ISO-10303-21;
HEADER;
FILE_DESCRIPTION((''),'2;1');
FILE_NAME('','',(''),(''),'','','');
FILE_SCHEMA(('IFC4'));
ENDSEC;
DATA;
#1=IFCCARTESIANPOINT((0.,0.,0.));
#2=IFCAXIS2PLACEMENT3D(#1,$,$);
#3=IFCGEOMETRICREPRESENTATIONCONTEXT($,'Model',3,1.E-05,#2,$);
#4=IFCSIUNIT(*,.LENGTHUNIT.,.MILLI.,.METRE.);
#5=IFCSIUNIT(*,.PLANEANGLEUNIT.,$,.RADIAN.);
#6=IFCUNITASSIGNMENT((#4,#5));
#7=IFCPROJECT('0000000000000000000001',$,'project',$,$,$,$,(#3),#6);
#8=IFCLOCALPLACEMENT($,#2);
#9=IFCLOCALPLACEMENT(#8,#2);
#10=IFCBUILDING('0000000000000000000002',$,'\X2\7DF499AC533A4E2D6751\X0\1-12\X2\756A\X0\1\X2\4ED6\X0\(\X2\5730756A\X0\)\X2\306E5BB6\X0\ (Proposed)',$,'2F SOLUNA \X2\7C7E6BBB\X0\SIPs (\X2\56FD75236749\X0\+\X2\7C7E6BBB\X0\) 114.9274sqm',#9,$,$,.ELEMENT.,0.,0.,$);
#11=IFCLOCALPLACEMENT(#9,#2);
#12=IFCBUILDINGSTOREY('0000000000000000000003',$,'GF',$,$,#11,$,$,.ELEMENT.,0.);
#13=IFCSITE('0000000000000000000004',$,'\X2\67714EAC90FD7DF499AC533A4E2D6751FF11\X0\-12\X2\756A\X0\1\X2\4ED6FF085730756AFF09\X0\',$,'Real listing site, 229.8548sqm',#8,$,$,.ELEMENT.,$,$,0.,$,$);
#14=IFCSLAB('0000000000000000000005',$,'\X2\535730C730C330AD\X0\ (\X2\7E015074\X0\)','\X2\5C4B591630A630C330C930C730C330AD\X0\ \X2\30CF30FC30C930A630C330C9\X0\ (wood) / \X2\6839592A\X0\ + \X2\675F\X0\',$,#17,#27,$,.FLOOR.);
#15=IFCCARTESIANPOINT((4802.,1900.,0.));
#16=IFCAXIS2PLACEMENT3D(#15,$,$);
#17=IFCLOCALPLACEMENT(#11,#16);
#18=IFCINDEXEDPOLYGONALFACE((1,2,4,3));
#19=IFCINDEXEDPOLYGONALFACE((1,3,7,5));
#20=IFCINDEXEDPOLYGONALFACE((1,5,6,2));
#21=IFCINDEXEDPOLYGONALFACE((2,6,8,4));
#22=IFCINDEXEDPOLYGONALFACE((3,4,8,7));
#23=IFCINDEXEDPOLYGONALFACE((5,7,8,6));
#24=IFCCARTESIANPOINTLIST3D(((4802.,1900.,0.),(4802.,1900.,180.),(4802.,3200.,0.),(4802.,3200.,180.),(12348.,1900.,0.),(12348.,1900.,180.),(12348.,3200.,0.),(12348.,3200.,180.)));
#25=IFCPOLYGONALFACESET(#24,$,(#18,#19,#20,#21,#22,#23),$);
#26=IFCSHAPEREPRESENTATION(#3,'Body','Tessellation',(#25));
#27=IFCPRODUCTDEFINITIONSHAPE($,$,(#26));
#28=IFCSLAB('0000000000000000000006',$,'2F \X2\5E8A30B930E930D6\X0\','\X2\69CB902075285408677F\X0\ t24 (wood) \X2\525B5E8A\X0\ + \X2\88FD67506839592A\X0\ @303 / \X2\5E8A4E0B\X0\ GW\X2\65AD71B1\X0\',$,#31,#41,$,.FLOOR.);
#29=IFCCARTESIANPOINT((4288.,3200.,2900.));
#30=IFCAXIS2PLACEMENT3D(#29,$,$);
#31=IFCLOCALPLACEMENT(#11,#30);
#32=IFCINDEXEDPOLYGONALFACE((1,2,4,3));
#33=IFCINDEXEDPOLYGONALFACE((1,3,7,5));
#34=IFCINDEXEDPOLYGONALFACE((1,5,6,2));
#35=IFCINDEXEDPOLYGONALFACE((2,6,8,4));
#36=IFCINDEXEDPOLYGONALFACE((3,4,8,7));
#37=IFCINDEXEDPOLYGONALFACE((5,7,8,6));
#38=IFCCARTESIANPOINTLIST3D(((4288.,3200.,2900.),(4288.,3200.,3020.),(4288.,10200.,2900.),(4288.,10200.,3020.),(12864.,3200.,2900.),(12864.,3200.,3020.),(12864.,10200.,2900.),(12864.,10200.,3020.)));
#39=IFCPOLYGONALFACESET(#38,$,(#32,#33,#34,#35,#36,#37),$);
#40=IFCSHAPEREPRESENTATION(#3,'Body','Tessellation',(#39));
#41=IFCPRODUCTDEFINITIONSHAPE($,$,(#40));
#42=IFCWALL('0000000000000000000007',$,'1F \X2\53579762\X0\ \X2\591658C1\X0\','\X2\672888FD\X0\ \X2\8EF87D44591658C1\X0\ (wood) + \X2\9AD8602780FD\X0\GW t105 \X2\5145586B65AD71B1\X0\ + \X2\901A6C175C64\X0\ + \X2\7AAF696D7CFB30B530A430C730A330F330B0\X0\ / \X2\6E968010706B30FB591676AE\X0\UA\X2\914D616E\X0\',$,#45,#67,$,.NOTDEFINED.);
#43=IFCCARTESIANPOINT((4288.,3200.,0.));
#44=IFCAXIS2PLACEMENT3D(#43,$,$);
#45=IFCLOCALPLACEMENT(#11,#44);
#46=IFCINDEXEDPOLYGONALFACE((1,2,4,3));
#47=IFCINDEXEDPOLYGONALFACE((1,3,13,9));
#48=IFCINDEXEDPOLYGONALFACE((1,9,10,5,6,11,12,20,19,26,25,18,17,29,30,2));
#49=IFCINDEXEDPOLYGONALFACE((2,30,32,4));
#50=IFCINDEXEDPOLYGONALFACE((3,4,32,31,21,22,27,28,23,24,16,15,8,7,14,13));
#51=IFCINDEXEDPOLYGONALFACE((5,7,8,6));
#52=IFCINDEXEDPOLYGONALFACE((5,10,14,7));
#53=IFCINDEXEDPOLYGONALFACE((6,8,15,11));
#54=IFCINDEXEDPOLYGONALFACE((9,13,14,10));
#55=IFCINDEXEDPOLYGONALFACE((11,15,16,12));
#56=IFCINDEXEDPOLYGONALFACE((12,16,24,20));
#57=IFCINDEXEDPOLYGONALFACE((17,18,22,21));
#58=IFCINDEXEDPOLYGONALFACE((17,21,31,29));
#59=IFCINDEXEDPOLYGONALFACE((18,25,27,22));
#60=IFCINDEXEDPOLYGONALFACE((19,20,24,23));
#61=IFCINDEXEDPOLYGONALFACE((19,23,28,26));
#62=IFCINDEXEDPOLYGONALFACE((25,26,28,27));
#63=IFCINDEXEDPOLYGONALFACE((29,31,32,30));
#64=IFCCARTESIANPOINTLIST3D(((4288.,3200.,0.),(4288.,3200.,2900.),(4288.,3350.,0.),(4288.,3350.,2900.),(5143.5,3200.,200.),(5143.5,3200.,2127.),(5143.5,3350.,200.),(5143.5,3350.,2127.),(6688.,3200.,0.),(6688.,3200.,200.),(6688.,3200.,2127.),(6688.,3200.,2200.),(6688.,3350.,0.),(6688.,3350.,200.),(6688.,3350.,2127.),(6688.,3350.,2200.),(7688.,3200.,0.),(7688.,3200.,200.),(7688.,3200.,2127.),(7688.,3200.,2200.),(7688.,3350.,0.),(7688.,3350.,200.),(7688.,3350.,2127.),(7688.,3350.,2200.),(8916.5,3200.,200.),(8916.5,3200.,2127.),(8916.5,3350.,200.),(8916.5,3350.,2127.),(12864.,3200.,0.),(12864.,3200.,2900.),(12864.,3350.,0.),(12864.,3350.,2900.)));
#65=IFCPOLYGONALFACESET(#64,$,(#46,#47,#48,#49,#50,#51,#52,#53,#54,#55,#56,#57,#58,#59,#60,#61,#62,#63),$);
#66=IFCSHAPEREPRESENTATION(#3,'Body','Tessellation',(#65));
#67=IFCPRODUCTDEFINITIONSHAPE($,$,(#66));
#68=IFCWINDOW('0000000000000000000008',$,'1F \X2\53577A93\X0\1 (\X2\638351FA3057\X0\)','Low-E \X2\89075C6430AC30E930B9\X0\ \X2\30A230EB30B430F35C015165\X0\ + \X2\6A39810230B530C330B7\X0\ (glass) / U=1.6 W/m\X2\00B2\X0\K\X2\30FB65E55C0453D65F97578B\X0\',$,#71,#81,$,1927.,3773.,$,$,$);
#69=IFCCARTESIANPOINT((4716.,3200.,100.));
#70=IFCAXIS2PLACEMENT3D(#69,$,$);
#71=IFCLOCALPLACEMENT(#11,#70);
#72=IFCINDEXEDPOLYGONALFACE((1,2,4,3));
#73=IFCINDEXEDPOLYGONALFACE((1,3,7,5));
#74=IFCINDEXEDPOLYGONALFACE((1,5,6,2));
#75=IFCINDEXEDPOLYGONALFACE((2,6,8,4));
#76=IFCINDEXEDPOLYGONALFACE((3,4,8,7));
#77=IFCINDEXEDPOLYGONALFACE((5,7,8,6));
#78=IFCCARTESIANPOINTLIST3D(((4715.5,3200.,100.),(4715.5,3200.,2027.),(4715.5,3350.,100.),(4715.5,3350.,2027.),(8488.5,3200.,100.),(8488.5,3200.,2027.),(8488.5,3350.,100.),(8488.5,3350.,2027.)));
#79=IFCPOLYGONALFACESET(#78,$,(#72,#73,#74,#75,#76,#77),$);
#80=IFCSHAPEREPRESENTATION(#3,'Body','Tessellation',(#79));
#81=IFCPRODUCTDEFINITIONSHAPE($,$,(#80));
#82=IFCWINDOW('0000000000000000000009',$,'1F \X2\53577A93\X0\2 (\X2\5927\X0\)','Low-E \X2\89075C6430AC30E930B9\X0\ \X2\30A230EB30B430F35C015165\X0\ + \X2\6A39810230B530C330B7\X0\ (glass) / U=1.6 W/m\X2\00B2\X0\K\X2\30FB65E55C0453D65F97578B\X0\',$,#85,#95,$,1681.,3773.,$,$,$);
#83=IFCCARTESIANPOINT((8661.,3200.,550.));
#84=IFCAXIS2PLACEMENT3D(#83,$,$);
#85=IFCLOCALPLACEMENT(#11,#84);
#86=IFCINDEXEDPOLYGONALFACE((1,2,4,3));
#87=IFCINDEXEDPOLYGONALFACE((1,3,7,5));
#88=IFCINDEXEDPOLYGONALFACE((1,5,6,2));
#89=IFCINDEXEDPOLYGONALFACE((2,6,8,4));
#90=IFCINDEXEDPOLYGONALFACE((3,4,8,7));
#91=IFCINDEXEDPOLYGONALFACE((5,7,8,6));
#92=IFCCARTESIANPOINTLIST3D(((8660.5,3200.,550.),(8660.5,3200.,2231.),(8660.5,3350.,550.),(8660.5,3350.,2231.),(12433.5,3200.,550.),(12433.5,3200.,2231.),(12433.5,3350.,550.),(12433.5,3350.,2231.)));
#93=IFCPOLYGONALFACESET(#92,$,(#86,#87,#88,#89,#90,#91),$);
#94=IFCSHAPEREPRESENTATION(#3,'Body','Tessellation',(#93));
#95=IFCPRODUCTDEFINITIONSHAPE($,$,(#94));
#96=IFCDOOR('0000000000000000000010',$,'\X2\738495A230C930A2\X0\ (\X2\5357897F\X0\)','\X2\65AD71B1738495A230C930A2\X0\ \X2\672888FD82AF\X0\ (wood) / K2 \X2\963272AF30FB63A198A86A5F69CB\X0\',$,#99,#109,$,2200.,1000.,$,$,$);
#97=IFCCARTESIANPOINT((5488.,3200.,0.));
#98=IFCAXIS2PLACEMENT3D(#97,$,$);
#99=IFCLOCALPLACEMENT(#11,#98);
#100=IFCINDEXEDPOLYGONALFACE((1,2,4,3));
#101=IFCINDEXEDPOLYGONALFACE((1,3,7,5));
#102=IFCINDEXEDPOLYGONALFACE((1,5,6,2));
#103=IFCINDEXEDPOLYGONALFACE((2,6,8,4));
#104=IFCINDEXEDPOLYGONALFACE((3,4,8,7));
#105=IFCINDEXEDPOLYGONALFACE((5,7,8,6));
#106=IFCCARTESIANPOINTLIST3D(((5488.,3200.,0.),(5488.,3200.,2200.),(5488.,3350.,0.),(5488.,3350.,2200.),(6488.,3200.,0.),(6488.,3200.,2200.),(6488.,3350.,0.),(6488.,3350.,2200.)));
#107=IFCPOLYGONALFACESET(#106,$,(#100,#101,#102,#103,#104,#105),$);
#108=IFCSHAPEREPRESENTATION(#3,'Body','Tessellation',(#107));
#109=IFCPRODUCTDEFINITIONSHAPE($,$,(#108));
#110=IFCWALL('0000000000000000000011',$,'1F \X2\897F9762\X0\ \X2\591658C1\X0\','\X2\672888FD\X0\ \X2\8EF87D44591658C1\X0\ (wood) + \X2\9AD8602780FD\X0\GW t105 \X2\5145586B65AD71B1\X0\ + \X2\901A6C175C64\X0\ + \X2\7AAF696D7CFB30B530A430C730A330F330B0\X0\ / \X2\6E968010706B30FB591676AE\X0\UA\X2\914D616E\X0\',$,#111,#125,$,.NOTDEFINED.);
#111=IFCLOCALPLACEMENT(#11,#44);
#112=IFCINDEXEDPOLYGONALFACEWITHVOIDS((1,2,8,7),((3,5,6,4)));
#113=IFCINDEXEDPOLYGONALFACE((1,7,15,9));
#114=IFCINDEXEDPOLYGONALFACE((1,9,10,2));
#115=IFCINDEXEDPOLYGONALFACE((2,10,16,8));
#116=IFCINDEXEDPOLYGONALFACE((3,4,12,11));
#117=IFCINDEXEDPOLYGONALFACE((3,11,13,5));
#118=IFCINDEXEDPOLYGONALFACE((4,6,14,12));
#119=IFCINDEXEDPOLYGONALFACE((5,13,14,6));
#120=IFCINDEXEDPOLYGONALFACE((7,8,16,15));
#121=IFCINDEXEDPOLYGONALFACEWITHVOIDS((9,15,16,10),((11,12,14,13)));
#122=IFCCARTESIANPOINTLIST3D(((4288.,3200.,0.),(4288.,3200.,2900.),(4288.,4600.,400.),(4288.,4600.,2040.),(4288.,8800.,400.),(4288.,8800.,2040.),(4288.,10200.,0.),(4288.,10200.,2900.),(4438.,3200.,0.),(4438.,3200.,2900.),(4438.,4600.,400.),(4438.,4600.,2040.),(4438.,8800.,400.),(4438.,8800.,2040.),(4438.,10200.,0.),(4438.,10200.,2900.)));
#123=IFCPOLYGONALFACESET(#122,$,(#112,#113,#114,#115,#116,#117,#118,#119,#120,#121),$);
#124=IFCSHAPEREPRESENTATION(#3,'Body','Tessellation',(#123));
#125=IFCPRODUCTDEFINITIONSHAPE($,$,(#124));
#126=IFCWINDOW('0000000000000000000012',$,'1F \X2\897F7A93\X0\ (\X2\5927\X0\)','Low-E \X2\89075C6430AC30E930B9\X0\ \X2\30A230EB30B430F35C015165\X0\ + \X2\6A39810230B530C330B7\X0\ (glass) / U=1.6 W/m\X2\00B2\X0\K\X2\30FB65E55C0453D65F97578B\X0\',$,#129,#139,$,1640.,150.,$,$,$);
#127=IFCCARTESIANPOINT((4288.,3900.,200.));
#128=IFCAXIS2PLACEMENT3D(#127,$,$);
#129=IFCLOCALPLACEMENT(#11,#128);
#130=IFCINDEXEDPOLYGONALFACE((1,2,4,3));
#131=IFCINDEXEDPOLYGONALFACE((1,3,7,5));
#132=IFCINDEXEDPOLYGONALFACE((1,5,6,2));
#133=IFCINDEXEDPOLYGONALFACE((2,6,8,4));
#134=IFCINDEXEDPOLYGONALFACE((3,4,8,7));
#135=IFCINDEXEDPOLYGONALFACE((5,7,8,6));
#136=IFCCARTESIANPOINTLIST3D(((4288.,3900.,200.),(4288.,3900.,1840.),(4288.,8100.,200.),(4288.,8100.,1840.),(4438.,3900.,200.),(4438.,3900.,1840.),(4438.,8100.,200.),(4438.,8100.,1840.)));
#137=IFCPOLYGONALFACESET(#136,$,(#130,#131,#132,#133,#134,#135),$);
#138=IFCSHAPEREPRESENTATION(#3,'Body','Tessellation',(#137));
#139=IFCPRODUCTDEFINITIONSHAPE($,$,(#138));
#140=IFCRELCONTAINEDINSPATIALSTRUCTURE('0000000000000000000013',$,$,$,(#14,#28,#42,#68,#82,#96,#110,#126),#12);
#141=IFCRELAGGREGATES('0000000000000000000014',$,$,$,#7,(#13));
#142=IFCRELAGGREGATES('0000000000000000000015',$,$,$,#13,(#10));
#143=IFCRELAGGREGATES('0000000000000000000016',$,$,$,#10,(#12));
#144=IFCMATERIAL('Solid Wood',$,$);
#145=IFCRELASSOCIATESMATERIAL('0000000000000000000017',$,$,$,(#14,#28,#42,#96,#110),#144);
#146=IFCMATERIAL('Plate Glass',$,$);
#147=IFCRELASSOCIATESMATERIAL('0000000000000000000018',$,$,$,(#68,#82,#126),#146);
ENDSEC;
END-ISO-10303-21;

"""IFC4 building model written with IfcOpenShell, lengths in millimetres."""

from ifc_helpers import new_model, si_unit, frame, frame_2d, origin, place, context, project, spatial, rectangle, extrude, material, element, fill, save


model = new_model("IFC4")

# Units and contexts
model_context = context("Model", 3, precision=1e-05, world=origin())
ifc_project = project(units=[si_unit("LENGTHUNIT", "METRE", prefix="MILLI"), si_unit("PLANEANGLEUNIT", "RADIAN")], contexts=[model_context])

# Site, building, storey
site_placement = place(None, origin())
site = spatial("IfcSite", under=ifc_project, at=site_placement, Name="東京都練馬区中村１-12番1他（地番）", ObjectType="Real listing site, 229.8548sqm", CompositionType="ELEMENT", RefElevation=0.0)
building_placement = place(site_placement, origin())
building = spatial("IfcBuilding", under=site, at=building_placement, Name="練馬区中村1-12番1他(地番)の家 (Proposed)", ObjectType="2F SOLUNA 籾殻SIPs (国産杉+籾殻) 114.9274sqm", CompositionType="ELEMENT", ElevationOfRefHeight=0.0, ElevationOfTerrain=0.0)
storey_placement = place(building_placement, origin())
storey = spatial("IfcBuildingStorey", under=building, at=storey_placement, Name="GF", CompositionType="ELEMENT", Elevation=0.0)

# Slabs
ifc_material_1 = material(Name="Solid Wood")
slab_1_placement = place(storey_placement, frame((4802.0, 1900.0, 0.0)))
element("IfcSlab", 1, at=slab_1_placement, inside=storey, material=ifc_material_1, Name="南デッキ (縁側)", Description="屋外ウッドデッキ ハードウッド (wood) / 根太 + 束", PredefinedType="FLOOR", context=model_context, shape_type="SweptSolid", body=[
    extrude(rectangle(XDim=7546.0, YDim=1300.0, at=frame_2d((3773.0, 650.0))), frame((4802.0, 1900.0, 0.0)), (0.0, 0.0, 1.0), 180.0),
])
slab_2_placement = place(storey_placement, frame((4288.0, 3200.0, 2900.0)))
element("IfcSlab", 2, at=slab_2_placement, inside=storey, material=ifc_material_1, Name="2F 床スラブ", Description="構造用合板 t24 (wood) 剛床 + 製材根太 @303 / 床下 GW断熱", PredefinedType="FLOOR", context=model_context, shape_type="SweptSolid", body=[
    extrude(rectangle(XDim=8576.0, YDim=7000.0, at=frame_2d((4288.0, 3500.0))), frame((4288.0, 3200.0, 2900.0)), (0.0, 0.0, 1.0), 120.0),
])

# Wall, openings, windows, door
wall_1_placement = place(storey_placement, frame((4288.0, 3200.0, 0.0)))
wall_1 = element("IfcWall", 3, at=wall_1_placement, inside=storey, material=ifc_material_1, Name="1F 南面 外壁", Description="木製 軸組外壁 (wood) + 高性能GW t105 充填断熱 + 通気層 + 窯業系サイディング / 準耐火・外皮UA配慮", PredefinedType="NOTDEFINED", context=model_context, shape_type="SweptSolid", body=[
    extrude(rectangle(XDim=8576.0, YDim=150.0, at=frame_2d((4288.0, 75.0))), frame((4288.0, 3200.0, 0.0)), (0.0, 0.0, 1.0), 2900.0),
])
opening_1_placement = place(storey_placement, frame((4716.0, 3200.0, 100.0)))
opening_1 = element("IfcOpeningElement", 4, at=opening_1_placement, cuts=wall_1, PredefinedType="NOTDEFINED", context=model_context, shape_type="SweptSolid", body=[
    extrude(rectangle(XDim=3773.0, YDim=150.0, at=frame_2d((1886.0, 75.0))), frame((4716.0, 3200.0, 100.0)), (0.0, 0.0, 1.0), 1927.0),
])
opening_2_placement = place(storey_placement, frame((8661.0, 3200.0, 550.0)))
opening_2 = element("IfcOpeningElement", 5, at=opening_2_placement, cuts=wall_1, PredefinedType="NOTDEFINED", context=model_context, shape_type="SweptSolid", body=[
    extrude(rectangle(XDim=3773.0, YDim=150.0, at=frame_2d((1886.0, 75.0))), frame((8661.0, 3200.0, 550.0)), (0.0, 0.0, 1.0), 1681.0),
])
opening_3_placement = place(storey_placement, frame((5488.0, 3200.0, 0.0)))
opening_3 = element("IfcOpeningElement", 6, at=opening_3_placement, cuts=wall_1, PredefinedType="NOTDEFINED", context=model_context, shape_type="SweptSolid", body=[
    extrude(rectangle(XDim=1000.0, YDim=150.0, at=frame_2d((500.0, 75.0))), frame((5488.0, 3200.0, 0.0)), (0.0, 0.0, 1.0), 2200.0),
])
ifc_material_2 = material(Name="Plate Glass")
window_1_placement = place(storey_placement, frame((4716.0, 3200.0, 100.0)))
window_1 = element("IfcWindow", 7, at=window_1_placement, inside=storey, material=ifc_material_2, Name="1F 南窓1 (掃出し)", Description="Low-E 複層ガラス アルゴン封入 + 樹脂サッシ (glass) / U=1.6 W/m²K・日射取得型", OverallHeight=1927.0, OverallWidth=3773.0, context=model_context, shape_type="SweptSolid", body=[
    extrude(rectangle(XDim=3773.0, YDim=150.0, at=frame_2d((1886.0, 75.0))), frame((4716.0, 3200.0, 100.0)), (0.0, 0.0, 1.0), 1927.0),
])
fill(opening_1, window_1)
window_2_placement = place(storey_placement, frame((8661.0, 3200.0, 550.0)))
window_2 = element("IfcWindow", 8, at=window_2_placement, inside=storey, material=ifc_material_2, Name="1F 南窓2 (大)", Description="Low-E 複層ガラス アルゴン封入 + 樹脂サッシ (glass) / U=1.6 W/m²K・日射取得型", OverallHeight=1681.0, OverallWidth=3773.0, context=model_context, shape_type="SweptSolid", body=[
    extrude(rectangle(XDim=3773.0, YDim=150.0, at=frame_2d((1886.0, 75.0))), frame((8661.0, 3200.0, 550.0)), (0.0, 0.0, 1.0), 1681.0),
])
fill(opening_2, window_2)
door_placement = place(storey_placement, frame((5488.0, 3200.0, 0.0)))
door = element("IfcDoor", 9, at=door_placement, inside=storey, material=ifc_material_1, Name="玄関ドア (南西)", Description="断熱玄関ドア 木製芯 (wood) / K2 防犯・採風機構", OverallHeight=2200.0, OverallWidth=1000.0, context=model_context, shape_type="SweptSolid", body=[
    extrude(rectangle(XDim=1000.0, YDim=150.0, at=frame_2d((500.0, 75.0))), frame((5488.0, 3200.0, 0.0)), (0.0, 0.0, 1.0), 2200.0),
])
fill(opening_3, door)

# Wall, opening, window
wall_2_placement = place(storey_placement, frame((4288.0, 3200.0, 0.0)))
wall_2 = element("IfcWall", 10, at=wall_2_placement, inside=storey, material=ifc_material_1, Name="1F 西面 外壁", Description="木製 軸組外壁 (wood) + 高性能GW t105 充填断熱 + 通気層 + 窯業系サイディング / 準耐火・外皮UA配慮", PredefinedType="NOTDEFINED", context=model_context, shape_type="SweptSolid", body=[
    extrude(rectangle(XDim=150.0, YDim=7000.0, at=frame_2d((75.0, 3500.0))), frame((4288.0, 3200.0, 0.0)), (0.0, 0.0, 1.0), 2900.0),
])
opening_4_placement = place(storey_placement, frame((4288.0, 3900.0, 200.0)))
opening_4 = element("IfcOpeningElement", 11, at=opening_4_placement, cuts=wall_2, PredefinedType="NOTDEFINED", context=model_context, shape_type="SweptSolid", body=[
    extrude(rectangle(XDim=150.0, YDim=4200.0, at=frame_2d((75.0, 2100.0))), frame((4288.0, 3900.0, 200.0)), (0.0, 0.0, 1.0), 1640.0),
])
window_3_placement = place(storey_placement, frame((4288.0, 3900.0, 200.0)))
window_3 = element("IfcWindow", 12, at=window_3_placement, inside=storey, material=ifc_material_2, Name="1F 西窓 (大)", Description="Low-E 複層ガラス アルゴン封入 + 樹脂サッシ (glass) / U=1.6 W/m²K・日射取得型", OverallHeight=1640.0, OverallWidth=150.0, context=model_context, shape_type="SweptSolid", body=[
    extrude(rectangle(XDim=150.0, YDim=4200.0, at=frame_2d((75.0, 2100.0))), frame((4288.0, 3900.0, 200.0)), (0.0, 0.0, 1.0), 1640.0),
])
fill(opening_4, window_3)

save(model, "model.ifc")
